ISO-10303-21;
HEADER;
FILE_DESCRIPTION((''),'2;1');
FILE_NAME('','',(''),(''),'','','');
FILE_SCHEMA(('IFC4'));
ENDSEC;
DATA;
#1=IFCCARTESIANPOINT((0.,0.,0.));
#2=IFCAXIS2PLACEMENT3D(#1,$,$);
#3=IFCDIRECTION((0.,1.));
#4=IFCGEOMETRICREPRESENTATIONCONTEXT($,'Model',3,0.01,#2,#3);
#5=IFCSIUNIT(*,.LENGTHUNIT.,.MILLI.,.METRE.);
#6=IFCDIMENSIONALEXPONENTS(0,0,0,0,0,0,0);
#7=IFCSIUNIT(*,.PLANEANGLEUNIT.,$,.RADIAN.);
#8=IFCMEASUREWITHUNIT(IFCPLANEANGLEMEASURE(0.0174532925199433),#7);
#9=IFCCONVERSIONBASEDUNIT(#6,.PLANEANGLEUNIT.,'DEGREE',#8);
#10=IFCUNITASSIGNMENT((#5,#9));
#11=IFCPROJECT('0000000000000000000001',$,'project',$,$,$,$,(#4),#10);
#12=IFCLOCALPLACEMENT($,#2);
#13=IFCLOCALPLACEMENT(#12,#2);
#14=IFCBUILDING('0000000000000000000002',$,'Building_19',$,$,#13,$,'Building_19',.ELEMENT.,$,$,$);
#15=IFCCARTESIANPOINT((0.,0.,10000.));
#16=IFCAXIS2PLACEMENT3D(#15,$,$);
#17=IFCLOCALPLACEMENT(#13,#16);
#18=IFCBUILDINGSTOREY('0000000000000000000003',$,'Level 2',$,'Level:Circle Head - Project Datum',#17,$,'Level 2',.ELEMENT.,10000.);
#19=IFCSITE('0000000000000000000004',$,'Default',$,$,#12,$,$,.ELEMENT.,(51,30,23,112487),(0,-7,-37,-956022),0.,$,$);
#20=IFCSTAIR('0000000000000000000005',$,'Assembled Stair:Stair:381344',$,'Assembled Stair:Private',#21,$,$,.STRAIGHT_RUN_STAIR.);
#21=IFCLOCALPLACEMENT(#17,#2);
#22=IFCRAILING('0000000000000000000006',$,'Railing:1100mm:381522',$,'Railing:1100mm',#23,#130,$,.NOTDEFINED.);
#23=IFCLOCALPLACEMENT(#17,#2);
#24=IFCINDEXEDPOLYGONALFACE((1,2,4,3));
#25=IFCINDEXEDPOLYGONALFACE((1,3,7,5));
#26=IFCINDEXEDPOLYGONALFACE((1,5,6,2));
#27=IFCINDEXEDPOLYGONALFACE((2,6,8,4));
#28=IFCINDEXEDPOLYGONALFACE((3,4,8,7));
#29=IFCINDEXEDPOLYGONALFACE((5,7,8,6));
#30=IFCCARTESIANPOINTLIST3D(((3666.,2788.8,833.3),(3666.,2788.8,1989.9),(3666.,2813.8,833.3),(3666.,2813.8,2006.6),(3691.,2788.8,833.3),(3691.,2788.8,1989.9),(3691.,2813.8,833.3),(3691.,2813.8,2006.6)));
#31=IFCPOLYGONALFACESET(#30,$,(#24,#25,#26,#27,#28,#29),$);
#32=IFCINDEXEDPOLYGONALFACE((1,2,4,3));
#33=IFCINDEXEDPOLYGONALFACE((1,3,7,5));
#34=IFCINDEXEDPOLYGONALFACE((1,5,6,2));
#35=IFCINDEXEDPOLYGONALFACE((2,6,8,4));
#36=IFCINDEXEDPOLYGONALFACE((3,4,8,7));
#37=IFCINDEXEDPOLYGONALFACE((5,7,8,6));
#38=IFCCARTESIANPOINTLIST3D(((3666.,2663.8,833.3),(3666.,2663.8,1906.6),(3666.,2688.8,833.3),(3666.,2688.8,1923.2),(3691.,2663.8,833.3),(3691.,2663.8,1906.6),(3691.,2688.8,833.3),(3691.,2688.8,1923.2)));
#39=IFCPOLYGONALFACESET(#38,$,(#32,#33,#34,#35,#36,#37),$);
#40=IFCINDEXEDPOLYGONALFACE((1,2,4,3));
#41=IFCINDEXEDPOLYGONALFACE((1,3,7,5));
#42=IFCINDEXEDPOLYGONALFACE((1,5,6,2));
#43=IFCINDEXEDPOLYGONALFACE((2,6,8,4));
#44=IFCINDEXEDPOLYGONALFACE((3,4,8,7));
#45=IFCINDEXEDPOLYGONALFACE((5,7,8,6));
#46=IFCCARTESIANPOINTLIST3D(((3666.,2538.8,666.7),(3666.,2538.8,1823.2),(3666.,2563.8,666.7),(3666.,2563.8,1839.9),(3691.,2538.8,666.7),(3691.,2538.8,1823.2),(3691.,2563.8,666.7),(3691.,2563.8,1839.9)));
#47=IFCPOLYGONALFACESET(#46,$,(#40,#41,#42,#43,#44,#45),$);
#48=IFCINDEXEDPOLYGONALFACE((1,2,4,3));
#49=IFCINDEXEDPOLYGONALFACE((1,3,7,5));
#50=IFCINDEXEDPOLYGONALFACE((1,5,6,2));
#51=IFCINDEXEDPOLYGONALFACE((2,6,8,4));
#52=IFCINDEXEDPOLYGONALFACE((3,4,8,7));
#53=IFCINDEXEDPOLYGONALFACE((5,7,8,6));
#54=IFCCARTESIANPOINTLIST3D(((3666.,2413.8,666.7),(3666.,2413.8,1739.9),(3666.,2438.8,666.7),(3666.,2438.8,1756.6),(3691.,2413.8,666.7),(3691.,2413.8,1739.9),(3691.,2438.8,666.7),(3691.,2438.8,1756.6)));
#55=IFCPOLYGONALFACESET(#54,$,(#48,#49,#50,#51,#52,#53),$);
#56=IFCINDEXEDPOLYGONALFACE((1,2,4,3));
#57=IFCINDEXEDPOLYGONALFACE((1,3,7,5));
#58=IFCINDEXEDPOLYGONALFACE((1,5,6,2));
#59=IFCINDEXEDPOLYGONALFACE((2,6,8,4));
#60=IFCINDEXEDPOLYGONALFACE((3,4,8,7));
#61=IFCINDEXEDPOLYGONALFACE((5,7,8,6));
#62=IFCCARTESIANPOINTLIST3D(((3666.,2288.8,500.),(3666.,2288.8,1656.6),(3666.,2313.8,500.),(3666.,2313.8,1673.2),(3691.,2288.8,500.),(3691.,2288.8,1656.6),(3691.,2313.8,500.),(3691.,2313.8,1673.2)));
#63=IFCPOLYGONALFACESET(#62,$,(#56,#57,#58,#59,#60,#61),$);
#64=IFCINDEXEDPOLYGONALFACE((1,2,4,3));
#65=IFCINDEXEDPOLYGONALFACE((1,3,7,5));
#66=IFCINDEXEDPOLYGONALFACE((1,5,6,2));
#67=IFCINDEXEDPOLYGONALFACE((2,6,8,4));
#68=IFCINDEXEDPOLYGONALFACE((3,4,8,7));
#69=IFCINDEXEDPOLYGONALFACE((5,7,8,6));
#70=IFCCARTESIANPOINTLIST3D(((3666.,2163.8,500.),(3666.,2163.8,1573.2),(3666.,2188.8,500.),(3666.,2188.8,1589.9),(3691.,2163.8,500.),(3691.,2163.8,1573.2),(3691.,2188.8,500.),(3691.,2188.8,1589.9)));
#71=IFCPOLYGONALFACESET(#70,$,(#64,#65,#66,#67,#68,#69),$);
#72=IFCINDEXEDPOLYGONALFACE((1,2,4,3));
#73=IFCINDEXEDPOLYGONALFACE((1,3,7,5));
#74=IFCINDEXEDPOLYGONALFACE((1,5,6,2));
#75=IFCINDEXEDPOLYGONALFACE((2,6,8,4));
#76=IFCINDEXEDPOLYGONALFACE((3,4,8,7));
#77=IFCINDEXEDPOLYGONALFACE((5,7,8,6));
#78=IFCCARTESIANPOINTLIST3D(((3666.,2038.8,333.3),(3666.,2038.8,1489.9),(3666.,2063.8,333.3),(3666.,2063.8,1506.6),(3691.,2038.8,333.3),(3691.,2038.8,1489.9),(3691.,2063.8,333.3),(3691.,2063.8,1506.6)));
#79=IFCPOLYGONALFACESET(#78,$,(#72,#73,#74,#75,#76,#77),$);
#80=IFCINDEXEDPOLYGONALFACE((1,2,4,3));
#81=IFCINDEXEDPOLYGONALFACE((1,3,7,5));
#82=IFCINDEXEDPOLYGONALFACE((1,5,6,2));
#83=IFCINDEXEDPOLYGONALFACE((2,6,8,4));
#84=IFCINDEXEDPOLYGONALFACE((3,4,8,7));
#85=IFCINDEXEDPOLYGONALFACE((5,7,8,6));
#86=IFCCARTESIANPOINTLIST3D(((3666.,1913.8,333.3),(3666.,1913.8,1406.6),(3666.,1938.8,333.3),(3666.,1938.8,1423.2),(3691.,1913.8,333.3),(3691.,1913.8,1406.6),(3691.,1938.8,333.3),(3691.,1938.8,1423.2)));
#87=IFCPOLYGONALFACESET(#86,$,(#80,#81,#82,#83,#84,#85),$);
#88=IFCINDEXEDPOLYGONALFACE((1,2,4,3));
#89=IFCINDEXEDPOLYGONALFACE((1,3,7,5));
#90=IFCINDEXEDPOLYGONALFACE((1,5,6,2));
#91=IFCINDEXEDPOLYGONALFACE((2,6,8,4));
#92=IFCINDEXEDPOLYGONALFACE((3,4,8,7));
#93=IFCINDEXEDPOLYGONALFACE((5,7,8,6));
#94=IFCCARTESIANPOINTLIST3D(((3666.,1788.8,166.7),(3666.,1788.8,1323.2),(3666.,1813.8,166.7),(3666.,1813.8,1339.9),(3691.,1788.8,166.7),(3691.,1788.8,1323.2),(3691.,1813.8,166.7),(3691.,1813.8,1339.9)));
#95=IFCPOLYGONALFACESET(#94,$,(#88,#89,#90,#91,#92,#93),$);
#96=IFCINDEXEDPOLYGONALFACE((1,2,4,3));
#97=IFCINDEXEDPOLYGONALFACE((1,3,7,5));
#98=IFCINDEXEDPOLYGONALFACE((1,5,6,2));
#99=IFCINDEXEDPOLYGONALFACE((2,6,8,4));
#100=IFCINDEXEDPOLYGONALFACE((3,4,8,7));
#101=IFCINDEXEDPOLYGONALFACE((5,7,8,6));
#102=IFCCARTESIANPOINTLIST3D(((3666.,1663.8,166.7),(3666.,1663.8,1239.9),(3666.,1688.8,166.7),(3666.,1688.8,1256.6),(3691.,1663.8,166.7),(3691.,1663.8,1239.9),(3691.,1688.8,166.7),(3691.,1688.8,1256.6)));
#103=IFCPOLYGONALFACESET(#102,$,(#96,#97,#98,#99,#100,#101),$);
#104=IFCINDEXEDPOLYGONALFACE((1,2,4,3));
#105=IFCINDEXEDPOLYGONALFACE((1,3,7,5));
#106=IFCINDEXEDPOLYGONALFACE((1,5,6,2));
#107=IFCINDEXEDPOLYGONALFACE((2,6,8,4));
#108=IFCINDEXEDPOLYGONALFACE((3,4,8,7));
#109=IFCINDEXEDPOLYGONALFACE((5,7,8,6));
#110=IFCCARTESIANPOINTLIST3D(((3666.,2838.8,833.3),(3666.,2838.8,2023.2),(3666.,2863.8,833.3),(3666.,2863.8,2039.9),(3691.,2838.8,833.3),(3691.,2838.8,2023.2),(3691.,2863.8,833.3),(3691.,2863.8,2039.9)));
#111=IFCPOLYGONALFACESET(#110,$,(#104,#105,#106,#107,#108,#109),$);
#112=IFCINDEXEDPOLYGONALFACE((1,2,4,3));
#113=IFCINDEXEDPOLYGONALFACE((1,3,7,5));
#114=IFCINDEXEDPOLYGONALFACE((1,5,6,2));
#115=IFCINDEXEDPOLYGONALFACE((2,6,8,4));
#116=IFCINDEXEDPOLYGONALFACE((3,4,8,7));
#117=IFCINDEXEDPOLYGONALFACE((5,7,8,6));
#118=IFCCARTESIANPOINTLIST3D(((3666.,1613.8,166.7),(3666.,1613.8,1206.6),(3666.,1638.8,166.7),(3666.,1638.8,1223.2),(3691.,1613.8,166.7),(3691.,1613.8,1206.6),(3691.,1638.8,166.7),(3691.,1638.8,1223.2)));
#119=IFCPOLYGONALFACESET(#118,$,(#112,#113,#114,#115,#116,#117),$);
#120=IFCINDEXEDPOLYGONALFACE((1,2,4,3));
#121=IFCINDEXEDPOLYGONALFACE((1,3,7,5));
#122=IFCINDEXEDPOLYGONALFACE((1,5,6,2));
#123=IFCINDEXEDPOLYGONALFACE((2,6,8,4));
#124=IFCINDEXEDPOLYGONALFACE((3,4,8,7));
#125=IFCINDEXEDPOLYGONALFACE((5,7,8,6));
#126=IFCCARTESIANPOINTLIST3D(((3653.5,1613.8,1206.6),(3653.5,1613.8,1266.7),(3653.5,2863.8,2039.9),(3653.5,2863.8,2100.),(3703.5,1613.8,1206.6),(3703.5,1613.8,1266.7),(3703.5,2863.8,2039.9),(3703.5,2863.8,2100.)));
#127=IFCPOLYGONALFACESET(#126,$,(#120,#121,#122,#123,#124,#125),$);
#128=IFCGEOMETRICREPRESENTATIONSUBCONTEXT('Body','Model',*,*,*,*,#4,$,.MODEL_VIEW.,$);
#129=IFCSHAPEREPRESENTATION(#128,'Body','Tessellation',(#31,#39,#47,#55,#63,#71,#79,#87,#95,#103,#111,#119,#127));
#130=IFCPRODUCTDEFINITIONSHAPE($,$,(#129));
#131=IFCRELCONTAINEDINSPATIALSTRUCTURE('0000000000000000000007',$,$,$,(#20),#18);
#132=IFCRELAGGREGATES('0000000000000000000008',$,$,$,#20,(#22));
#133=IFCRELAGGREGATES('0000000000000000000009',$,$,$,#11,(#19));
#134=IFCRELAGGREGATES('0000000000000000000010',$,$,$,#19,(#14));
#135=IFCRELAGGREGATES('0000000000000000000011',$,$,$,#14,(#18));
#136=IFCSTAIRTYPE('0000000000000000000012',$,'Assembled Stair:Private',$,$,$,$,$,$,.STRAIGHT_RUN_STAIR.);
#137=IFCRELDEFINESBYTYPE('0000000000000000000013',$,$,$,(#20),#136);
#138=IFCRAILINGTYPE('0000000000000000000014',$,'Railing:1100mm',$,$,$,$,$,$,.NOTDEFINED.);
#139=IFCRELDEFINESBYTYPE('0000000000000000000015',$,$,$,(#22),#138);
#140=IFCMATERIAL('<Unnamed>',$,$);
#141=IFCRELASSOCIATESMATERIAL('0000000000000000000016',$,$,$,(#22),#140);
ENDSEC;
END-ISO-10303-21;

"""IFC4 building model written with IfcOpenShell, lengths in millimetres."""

from ifc_helpers import new_model, entity, si_unit, converted_unit, direction, frame, origin, place, context, subcontext, project, spatial, indexed_curve, outline, extrude, material, type_object, element, aggregate, save


model = new_model("IFC4")

# Units and contexts
model_context = context("Model", 3, precision=0.01, world=origin(), true_north=direction((0.0, 1.0)))
body_context = subcontext(model_context, "Body", "Model", "MODEL_VIEW")
ifc_project = project(units=[si_unit("LENGTHUNIT", "METRE", prefix="MILLI"), converted_unit("PLANEANGLEUNIT", "DEGREE", entity("IfcPlaneAngleMeasure", 0.0174532925199433), si_unit("PLANEANGLEUNIT", "RADIAN"), dimensions=[0, 0, 0, 0, 0, 0, 0])], contexts=[model_context])

# Site, building, storey
site_placement = place(None, origin())
site = spatial("IfcSite", under=ifc_project, at=site_placement, Name="Default", CompositionType="ELEMENT", RefLatitude=(51, 30, 23, 112487), RefLongitude=(0, -7, -37, -956022), RefElevation=0.0)
building_placement = place(site_placement, origin())
building = spatial("IfcBuilding", under=site, at=building_placement, Name="Building_19", LongName="Building_19", CompositionType="ELEMENT")
storey_placement = place(building_placement, frame((0.0, 0.0, 10000.0)))
storey = spatial("IfcBuildingStorey", under=building, at=storey_placement, Name="Level 2", ObjectType="Level:Circle Head - Project Datum", LongName="Level 2", CompositionType="ELEMENT", Elevation=10000.0)

# Stair
stair_type = type_object("IfcStairType", Name="Assembled Stair:Private", PredefinedType="STRAIGHT_RUN_STAIR")
ifc_material_1 = material(Name="<Unnamed>")
stair_1_placement = place(storey_placement, origin())
stair_1 = element("IfcStair", 1, at=stair_1_placement, inside=storey, type_object=stair_type, Name="Assembled Stair:Stair:381344", ObjectType="Assembled Stair:Private", PredefinedType="STRAIGHT_RUN_STAIR")

# Railing
railing_type = type_object("IfcRailingType", Name="Railing:1100mm", PredefinedType="NOTDEFINED")
railing_1_placement = place(stair_1_placement, origin())
railing_1 = element("IfcRailing", 2, at=railing_1_placement, type_object=railing_type, material=ifc_material_1, Name="Railing:1100mm:381522", ObjectType="Railing:1100mm", PredefinedType="NOTDEFINED", context=body_context, shape_type="SweptSolid", body=[
    extrude(outline(indexed_curve([(-12.5, -582.5), (12.5, -582.5), (12.5, 590.8), (-12.5, 574.1), (-12.5, -582.5)], self_intersect=False)), frame((3666.0, 2801.3, 1415.8), z_axis=(1.0, 0.0, 0.0), x_axis=(0.0, 1.0, 0.0)), (0.0, 0.0, 1.0), 25.0),
    extrude(outline(indexed_curve([(-12.5, -540.8), (12.5, -540.8), (12.5, 549.1), (-12.5, 532.5), (-12.5, -540.8)], self_intersect=False)), frame((3666.0, 2676.3, 1374.1), z_axis=(1.0, 0.0, 0.0), x_axis=(0.0, 1.0, 0.0)), (0.0, 0.0, 1.0), 25.0),
    extrude(outline(indexed_curve([(-12.5, -582.5), (12.5, -582.5), (12.5, 590.8), (-12.5, 574.1), (-12.5, -582.5)], self_intersect=False)), frame((3666.0, 2551.3, 1249.1), z_axis=(1.0, 0.0, 0.0), x_axis=(0.0, 1.0, 0.0)), (0.0, 0.0, 1.0), 25.0),
    extrude(outline(indexed_curve([(-12.5, -540.8), (12.5, -540.8), (12.5, 549.1), (-12.5, 532.5), (-12.5, -540.8)], self_intersect=False)), frame((3666.0, 2426.3, 1207.5), z_axis=(1.0, 0.0, 0.0), x_axis=(0.0, 1.0, 0.0)), (0.0, 0.0, 1.0), 25.0),
    extrude(outline(indexed_curve([(-12.5, -582.5), (12.5, -582.5), (12.5, 590.8), (-12.5, 574.1), (-12.5, -582.5)], self_intersect=False)), frame((3666.0, 2301.3, 1082.5), z_axis=(1.0, 0.0, 0.0), x_axis=(0.0, 1.0, 0.0)), (0.0, 0.0, 1.0), 25.0),
    extrude(outline(indexed_curve([(-12.5, -540.8), (12.5, -540.8), (12.5, 549.1), (-12.5, 532.5), (-12.5, -540.8)], self_intersect=False)), frame((3666.0, 2176.3, 1040.8), z_axis=(1.0, 0.0, 0.0), x_axis=(0.0, 1.0, 0.0)), (0.0, 0.0, 1.0), 25.0),
    extrude(outline(indexed_curve([(-12.5, -582.5), (12.5, -582.5), (12.5, 590.8), (-12.5, 574.1), (-12.5, -582.5)], self_intersect=False)), frame((3666.0, 2051.3, 915.8), z_axis=(1.0, 0.0, 0.0), x_axis=(0.0, 1.0, 0.0)), (0.0, 0.0, 1.0), 25.0),
    extrude(outline(indexed_curve([(-12.5, -540.8), (12.5, -540.8), (12.5, 549.1), (-12.5, 532.5), (-12.5, -540.8)], self_intersect=False)), frame((3666.0, 1926.3, 874.1), z_axis=(1.0, 0.0, 0.0), x_axis=(0.0, 1.0, 0.0)), (0.0, 0.0, 1.0), 25.0),
    extrude(outline(indexed_curve([(-12.5, -582.5), (12.5, -582.5), (12.5, 590.8), (-12.5, 574.1), (-12.5, -582.5)], self_intersect=False)), frame((3666.0, 1801.3, 749.1), z_axis=(1.0, 0.0, 0.0), x_axis=(0.0, 1.0, 0.0)), (0.0, 0.0, 1.0), 25.0),
    extrude(outline(indexed_curve([(-12.5, -540.8), (12.5, -540.8), (12.5, 549.1), (-12.5, 532.5), (-12.5, -540.8)], self_intersect=False)), frame((3666.0, 1676.3, 707.5), z_axis=(1.0, 0.0, 0.0), x_axis=(0.0, 1.0, 0.0)), (0.0, 0.0, 1.0), 25.0),
    extrude(outline(indexed_curve([(-12.5, -599.1), (12.5, -599.1), (12.5, 607.5), (-12.5, 590.8), (-12.5, -599.1)], self_intersect=False)), frame((3666.0, 2851.3, 1432.5), z_axis=(1.0, 0.0, 0.0), x_axis=(0.0, 1.0, 0.0)), (0.0, 0.0, 1.0), 25.0),
    extrude(outline(indexed_curve([(-12.5, -524.1), (12.5, -524.1), (12.5, 532.5), (-12.5, 515.8), (-12.5, -524.1)], self_intersect=False)), frame((3666.0, 1626.3, 690.8), z_axis=(1.0, 0.0, 0.0), x_axis=(0.0, 1.0, 0.0)), (0.0, 0.0, 1.0), 25.0),
    extrude(outline(indexed_curve([(-767.8, -25.0), (734.5, -25.0), (767.8, 25.0), (-734.5, 25.0), (-767.8, -25.0)], self_intersect=False)), frame((3653.5, 2238.8, 1653.3), z_axis=(1.0, 0.0, 0.0), x_axis=(0.0, 0.83205, 0.5547)), (0.0, 0.0, 1.0), 50.0),
])
aggregate(stair_1, [railing_1])

save(model, "model.ifc")
